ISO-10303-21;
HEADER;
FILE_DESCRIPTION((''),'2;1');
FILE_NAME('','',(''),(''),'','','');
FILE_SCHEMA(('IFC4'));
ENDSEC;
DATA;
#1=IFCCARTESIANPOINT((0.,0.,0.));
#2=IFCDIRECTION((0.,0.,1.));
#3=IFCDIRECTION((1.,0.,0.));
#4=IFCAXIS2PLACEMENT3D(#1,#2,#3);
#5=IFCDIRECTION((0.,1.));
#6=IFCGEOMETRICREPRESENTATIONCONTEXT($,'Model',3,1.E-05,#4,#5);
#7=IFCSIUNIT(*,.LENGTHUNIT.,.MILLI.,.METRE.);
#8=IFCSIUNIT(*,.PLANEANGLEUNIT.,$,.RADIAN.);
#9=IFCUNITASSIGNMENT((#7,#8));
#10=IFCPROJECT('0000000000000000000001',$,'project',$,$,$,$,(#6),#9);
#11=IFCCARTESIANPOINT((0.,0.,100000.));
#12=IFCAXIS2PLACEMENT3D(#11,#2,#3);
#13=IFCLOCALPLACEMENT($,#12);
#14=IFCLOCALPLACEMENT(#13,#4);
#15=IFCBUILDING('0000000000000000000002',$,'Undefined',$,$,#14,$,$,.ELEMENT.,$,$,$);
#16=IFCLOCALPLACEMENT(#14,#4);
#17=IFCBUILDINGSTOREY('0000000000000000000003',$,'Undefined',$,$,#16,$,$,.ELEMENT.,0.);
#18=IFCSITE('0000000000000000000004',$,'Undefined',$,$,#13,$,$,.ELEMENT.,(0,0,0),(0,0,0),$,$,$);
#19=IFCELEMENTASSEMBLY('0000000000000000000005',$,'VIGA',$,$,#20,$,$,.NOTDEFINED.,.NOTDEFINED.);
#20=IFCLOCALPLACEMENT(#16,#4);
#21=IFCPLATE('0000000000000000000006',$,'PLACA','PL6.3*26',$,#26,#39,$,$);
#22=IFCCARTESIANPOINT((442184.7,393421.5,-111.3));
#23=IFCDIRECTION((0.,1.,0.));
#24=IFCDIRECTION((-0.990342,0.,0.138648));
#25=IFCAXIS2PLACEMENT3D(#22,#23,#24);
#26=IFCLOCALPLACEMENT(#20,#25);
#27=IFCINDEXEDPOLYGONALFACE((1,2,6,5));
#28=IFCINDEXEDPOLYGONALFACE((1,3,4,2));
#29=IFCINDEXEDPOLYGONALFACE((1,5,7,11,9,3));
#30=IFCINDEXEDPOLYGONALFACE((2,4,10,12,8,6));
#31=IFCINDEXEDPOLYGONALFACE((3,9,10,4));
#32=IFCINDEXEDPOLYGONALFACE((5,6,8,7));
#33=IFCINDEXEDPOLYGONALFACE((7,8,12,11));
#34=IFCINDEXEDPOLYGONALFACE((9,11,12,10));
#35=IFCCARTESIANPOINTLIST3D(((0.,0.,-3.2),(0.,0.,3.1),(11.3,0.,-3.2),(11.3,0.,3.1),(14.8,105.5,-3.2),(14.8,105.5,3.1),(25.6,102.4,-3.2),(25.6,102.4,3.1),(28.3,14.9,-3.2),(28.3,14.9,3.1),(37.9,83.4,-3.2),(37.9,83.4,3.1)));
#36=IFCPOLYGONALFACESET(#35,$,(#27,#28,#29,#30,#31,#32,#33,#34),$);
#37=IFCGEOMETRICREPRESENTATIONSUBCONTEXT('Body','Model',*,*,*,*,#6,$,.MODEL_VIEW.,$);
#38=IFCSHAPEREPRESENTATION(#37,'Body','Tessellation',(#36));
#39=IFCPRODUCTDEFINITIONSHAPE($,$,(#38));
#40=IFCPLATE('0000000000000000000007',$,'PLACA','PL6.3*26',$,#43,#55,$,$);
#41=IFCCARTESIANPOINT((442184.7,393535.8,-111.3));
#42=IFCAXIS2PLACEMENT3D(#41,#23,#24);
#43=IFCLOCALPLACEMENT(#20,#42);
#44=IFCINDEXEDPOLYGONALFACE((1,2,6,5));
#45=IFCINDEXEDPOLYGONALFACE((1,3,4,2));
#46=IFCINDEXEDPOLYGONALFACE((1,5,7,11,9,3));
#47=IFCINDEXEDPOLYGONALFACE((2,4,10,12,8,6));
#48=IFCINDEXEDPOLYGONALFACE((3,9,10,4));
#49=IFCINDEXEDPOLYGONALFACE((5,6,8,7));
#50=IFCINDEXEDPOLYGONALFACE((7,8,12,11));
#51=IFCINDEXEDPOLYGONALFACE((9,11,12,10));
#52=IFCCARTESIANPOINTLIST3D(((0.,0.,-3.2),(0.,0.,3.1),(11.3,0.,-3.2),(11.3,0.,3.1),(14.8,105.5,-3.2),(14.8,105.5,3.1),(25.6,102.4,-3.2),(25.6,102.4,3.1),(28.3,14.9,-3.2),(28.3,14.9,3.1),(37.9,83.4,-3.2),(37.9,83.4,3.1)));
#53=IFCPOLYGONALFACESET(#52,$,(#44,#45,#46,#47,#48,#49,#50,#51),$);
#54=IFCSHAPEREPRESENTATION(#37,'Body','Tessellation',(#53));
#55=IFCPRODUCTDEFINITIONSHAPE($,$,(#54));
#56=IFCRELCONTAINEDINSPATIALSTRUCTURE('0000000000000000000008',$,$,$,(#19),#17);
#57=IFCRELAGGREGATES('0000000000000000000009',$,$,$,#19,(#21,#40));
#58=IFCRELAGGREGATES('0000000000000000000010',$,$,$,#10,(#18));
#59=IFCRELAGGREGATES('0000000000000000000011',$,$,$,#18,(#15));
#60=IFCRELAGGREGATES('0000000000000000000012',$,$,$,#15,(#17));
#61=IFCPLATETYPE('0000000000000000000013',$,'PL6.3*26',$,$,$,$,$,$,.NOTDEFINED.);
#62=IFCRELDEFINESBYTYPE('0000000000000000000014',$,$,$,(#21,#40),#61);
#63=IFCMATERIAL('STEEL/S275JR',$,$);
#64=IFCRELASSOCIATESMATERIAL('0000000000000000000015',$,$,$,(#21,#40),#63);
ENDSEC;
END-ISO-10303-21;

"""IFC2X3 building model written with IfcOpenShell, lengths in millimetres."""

from ifc_helpers import new_model, si_unit, direction, frame, origin_with_axes, place, context, subcontext, project, spatial, polyline, outline, extrude, material, type_object, element, aggregate, save


model = new_model("IFC2X3")

# Units and contexts
model_context = context("Model", 3, precision=1e-05, world=origin_with_axes(), true_north=direction((0.0, 1.0)))
body_context = subcontext(model_context, "Body", "Model", "MODEL_VIEW")
ifc_project = project(units=[si_unit("LENGTHUNIT", "METRE", prefix="MILLI"), si_unit("PLANEANGLEUNIT", "RADIAN")], contexts=[model_context])

# Site, building, storey
site_placement = place(None, frame((0.0, 0.0, 100000.0), z_axis=(0.0, 0.0, 1.0), x_axis=(1.0, 0.0, 0.0)))
site = spatial("IfcSite", under=ifc_project, at=site_placement, Name="Undefined", CompositionType="ELEMENT", RefLatitude=(0, 0, 0), RefLongitude=(0, 0, 0))
building_placement = place(site_placement, origin_with_axes())
building = spatial("IfcBuilding", under=site, at=building_placement, Name="Undefined", CompositionType="ELEMENT")
storey_placement = place(building_placement, origin_with_axes())
storey = spatial("IfcBuildingStorey", under=building, at=storey_placement, Name="Undefined", CompositionType="ELEMENT", Elevation=0.0)

# Shared definitions
ifc_material = material(Name="STEEL/S275JR")

# Element assembly, plates
assembly_1_placement = place(storey_placement, origin_with_axes())
assembly_1 = element("IfcElementAssembly", 1, at=assembly_1_placement, inside=storey, Name="VIGA", AssemblyPlace="NOTDEFINED", PredefinedType="NOTDEFINED")
plate_type = type_object("IfcPlateType", Name="PL6.3*26", PredefinedType="NOTDEFINED")
plate_1_placement = place(assembly_1_placement, frame((442184.7, 393421.5, -111.3), z_axis=(0.0, 1.0, 0.0), x_axis=(-0.990342, 0.0, 0.138648)))
plate_1 = element("IfcPlate", 2, at=plate_1_placement, type_object=plate_type, material=ifc_material, Name="PLACA", Description="PL6.3*26", context=body_context, shape_type="SweptSolid", body=[
    extrude(outline(polyline([(0.0, 0.0), (11.3, 0.0), (28.3, 14.9), (37.9, 83.4), (25.6, 102.4), (14.8, 105.5), (0.0, 0.0)])), frame((0.0, 0.0, -3.1), z_axis=(0.0, 0.0, 1.0), x_axis=(1.0, 0.0, 0.0)), (0.0, 0.0, 1.0), 6.3),
])
plate_2_placement = place(assembly_1_placement, frame((442184.7, 393535.8, -111.3), z_axis=(0.0, 1.0, 0.0), x_axis=(-0.990342, 0.0, 0.138648)))
plate_2 = element("IfcPlate", 3, at=plate_2_placement, type_object=plate_type, material=ifc_material, Name="PLACA", Description="PL6.3*26", context=body_context, shape_type="SweptSolid", body=[
    extrude(outline(polyline([(0.0, 0.0), (11.3, 0.0), (28.3, 14.9), (37.9, 83.4), (25.6, 102.4), (14.8, 105.5), (0.0, 0.0)])), frame((0.0, 0.0, -3.1), z_axis=(0.0, 0.0, 1.0), x_axis=(1.0, 0.0, 0.0)), (0.0, 0.0, 1.0), 6.3),
])
aggregate(assembly_1, [plate_1, plate_2])

save(model, "model.ifc")
